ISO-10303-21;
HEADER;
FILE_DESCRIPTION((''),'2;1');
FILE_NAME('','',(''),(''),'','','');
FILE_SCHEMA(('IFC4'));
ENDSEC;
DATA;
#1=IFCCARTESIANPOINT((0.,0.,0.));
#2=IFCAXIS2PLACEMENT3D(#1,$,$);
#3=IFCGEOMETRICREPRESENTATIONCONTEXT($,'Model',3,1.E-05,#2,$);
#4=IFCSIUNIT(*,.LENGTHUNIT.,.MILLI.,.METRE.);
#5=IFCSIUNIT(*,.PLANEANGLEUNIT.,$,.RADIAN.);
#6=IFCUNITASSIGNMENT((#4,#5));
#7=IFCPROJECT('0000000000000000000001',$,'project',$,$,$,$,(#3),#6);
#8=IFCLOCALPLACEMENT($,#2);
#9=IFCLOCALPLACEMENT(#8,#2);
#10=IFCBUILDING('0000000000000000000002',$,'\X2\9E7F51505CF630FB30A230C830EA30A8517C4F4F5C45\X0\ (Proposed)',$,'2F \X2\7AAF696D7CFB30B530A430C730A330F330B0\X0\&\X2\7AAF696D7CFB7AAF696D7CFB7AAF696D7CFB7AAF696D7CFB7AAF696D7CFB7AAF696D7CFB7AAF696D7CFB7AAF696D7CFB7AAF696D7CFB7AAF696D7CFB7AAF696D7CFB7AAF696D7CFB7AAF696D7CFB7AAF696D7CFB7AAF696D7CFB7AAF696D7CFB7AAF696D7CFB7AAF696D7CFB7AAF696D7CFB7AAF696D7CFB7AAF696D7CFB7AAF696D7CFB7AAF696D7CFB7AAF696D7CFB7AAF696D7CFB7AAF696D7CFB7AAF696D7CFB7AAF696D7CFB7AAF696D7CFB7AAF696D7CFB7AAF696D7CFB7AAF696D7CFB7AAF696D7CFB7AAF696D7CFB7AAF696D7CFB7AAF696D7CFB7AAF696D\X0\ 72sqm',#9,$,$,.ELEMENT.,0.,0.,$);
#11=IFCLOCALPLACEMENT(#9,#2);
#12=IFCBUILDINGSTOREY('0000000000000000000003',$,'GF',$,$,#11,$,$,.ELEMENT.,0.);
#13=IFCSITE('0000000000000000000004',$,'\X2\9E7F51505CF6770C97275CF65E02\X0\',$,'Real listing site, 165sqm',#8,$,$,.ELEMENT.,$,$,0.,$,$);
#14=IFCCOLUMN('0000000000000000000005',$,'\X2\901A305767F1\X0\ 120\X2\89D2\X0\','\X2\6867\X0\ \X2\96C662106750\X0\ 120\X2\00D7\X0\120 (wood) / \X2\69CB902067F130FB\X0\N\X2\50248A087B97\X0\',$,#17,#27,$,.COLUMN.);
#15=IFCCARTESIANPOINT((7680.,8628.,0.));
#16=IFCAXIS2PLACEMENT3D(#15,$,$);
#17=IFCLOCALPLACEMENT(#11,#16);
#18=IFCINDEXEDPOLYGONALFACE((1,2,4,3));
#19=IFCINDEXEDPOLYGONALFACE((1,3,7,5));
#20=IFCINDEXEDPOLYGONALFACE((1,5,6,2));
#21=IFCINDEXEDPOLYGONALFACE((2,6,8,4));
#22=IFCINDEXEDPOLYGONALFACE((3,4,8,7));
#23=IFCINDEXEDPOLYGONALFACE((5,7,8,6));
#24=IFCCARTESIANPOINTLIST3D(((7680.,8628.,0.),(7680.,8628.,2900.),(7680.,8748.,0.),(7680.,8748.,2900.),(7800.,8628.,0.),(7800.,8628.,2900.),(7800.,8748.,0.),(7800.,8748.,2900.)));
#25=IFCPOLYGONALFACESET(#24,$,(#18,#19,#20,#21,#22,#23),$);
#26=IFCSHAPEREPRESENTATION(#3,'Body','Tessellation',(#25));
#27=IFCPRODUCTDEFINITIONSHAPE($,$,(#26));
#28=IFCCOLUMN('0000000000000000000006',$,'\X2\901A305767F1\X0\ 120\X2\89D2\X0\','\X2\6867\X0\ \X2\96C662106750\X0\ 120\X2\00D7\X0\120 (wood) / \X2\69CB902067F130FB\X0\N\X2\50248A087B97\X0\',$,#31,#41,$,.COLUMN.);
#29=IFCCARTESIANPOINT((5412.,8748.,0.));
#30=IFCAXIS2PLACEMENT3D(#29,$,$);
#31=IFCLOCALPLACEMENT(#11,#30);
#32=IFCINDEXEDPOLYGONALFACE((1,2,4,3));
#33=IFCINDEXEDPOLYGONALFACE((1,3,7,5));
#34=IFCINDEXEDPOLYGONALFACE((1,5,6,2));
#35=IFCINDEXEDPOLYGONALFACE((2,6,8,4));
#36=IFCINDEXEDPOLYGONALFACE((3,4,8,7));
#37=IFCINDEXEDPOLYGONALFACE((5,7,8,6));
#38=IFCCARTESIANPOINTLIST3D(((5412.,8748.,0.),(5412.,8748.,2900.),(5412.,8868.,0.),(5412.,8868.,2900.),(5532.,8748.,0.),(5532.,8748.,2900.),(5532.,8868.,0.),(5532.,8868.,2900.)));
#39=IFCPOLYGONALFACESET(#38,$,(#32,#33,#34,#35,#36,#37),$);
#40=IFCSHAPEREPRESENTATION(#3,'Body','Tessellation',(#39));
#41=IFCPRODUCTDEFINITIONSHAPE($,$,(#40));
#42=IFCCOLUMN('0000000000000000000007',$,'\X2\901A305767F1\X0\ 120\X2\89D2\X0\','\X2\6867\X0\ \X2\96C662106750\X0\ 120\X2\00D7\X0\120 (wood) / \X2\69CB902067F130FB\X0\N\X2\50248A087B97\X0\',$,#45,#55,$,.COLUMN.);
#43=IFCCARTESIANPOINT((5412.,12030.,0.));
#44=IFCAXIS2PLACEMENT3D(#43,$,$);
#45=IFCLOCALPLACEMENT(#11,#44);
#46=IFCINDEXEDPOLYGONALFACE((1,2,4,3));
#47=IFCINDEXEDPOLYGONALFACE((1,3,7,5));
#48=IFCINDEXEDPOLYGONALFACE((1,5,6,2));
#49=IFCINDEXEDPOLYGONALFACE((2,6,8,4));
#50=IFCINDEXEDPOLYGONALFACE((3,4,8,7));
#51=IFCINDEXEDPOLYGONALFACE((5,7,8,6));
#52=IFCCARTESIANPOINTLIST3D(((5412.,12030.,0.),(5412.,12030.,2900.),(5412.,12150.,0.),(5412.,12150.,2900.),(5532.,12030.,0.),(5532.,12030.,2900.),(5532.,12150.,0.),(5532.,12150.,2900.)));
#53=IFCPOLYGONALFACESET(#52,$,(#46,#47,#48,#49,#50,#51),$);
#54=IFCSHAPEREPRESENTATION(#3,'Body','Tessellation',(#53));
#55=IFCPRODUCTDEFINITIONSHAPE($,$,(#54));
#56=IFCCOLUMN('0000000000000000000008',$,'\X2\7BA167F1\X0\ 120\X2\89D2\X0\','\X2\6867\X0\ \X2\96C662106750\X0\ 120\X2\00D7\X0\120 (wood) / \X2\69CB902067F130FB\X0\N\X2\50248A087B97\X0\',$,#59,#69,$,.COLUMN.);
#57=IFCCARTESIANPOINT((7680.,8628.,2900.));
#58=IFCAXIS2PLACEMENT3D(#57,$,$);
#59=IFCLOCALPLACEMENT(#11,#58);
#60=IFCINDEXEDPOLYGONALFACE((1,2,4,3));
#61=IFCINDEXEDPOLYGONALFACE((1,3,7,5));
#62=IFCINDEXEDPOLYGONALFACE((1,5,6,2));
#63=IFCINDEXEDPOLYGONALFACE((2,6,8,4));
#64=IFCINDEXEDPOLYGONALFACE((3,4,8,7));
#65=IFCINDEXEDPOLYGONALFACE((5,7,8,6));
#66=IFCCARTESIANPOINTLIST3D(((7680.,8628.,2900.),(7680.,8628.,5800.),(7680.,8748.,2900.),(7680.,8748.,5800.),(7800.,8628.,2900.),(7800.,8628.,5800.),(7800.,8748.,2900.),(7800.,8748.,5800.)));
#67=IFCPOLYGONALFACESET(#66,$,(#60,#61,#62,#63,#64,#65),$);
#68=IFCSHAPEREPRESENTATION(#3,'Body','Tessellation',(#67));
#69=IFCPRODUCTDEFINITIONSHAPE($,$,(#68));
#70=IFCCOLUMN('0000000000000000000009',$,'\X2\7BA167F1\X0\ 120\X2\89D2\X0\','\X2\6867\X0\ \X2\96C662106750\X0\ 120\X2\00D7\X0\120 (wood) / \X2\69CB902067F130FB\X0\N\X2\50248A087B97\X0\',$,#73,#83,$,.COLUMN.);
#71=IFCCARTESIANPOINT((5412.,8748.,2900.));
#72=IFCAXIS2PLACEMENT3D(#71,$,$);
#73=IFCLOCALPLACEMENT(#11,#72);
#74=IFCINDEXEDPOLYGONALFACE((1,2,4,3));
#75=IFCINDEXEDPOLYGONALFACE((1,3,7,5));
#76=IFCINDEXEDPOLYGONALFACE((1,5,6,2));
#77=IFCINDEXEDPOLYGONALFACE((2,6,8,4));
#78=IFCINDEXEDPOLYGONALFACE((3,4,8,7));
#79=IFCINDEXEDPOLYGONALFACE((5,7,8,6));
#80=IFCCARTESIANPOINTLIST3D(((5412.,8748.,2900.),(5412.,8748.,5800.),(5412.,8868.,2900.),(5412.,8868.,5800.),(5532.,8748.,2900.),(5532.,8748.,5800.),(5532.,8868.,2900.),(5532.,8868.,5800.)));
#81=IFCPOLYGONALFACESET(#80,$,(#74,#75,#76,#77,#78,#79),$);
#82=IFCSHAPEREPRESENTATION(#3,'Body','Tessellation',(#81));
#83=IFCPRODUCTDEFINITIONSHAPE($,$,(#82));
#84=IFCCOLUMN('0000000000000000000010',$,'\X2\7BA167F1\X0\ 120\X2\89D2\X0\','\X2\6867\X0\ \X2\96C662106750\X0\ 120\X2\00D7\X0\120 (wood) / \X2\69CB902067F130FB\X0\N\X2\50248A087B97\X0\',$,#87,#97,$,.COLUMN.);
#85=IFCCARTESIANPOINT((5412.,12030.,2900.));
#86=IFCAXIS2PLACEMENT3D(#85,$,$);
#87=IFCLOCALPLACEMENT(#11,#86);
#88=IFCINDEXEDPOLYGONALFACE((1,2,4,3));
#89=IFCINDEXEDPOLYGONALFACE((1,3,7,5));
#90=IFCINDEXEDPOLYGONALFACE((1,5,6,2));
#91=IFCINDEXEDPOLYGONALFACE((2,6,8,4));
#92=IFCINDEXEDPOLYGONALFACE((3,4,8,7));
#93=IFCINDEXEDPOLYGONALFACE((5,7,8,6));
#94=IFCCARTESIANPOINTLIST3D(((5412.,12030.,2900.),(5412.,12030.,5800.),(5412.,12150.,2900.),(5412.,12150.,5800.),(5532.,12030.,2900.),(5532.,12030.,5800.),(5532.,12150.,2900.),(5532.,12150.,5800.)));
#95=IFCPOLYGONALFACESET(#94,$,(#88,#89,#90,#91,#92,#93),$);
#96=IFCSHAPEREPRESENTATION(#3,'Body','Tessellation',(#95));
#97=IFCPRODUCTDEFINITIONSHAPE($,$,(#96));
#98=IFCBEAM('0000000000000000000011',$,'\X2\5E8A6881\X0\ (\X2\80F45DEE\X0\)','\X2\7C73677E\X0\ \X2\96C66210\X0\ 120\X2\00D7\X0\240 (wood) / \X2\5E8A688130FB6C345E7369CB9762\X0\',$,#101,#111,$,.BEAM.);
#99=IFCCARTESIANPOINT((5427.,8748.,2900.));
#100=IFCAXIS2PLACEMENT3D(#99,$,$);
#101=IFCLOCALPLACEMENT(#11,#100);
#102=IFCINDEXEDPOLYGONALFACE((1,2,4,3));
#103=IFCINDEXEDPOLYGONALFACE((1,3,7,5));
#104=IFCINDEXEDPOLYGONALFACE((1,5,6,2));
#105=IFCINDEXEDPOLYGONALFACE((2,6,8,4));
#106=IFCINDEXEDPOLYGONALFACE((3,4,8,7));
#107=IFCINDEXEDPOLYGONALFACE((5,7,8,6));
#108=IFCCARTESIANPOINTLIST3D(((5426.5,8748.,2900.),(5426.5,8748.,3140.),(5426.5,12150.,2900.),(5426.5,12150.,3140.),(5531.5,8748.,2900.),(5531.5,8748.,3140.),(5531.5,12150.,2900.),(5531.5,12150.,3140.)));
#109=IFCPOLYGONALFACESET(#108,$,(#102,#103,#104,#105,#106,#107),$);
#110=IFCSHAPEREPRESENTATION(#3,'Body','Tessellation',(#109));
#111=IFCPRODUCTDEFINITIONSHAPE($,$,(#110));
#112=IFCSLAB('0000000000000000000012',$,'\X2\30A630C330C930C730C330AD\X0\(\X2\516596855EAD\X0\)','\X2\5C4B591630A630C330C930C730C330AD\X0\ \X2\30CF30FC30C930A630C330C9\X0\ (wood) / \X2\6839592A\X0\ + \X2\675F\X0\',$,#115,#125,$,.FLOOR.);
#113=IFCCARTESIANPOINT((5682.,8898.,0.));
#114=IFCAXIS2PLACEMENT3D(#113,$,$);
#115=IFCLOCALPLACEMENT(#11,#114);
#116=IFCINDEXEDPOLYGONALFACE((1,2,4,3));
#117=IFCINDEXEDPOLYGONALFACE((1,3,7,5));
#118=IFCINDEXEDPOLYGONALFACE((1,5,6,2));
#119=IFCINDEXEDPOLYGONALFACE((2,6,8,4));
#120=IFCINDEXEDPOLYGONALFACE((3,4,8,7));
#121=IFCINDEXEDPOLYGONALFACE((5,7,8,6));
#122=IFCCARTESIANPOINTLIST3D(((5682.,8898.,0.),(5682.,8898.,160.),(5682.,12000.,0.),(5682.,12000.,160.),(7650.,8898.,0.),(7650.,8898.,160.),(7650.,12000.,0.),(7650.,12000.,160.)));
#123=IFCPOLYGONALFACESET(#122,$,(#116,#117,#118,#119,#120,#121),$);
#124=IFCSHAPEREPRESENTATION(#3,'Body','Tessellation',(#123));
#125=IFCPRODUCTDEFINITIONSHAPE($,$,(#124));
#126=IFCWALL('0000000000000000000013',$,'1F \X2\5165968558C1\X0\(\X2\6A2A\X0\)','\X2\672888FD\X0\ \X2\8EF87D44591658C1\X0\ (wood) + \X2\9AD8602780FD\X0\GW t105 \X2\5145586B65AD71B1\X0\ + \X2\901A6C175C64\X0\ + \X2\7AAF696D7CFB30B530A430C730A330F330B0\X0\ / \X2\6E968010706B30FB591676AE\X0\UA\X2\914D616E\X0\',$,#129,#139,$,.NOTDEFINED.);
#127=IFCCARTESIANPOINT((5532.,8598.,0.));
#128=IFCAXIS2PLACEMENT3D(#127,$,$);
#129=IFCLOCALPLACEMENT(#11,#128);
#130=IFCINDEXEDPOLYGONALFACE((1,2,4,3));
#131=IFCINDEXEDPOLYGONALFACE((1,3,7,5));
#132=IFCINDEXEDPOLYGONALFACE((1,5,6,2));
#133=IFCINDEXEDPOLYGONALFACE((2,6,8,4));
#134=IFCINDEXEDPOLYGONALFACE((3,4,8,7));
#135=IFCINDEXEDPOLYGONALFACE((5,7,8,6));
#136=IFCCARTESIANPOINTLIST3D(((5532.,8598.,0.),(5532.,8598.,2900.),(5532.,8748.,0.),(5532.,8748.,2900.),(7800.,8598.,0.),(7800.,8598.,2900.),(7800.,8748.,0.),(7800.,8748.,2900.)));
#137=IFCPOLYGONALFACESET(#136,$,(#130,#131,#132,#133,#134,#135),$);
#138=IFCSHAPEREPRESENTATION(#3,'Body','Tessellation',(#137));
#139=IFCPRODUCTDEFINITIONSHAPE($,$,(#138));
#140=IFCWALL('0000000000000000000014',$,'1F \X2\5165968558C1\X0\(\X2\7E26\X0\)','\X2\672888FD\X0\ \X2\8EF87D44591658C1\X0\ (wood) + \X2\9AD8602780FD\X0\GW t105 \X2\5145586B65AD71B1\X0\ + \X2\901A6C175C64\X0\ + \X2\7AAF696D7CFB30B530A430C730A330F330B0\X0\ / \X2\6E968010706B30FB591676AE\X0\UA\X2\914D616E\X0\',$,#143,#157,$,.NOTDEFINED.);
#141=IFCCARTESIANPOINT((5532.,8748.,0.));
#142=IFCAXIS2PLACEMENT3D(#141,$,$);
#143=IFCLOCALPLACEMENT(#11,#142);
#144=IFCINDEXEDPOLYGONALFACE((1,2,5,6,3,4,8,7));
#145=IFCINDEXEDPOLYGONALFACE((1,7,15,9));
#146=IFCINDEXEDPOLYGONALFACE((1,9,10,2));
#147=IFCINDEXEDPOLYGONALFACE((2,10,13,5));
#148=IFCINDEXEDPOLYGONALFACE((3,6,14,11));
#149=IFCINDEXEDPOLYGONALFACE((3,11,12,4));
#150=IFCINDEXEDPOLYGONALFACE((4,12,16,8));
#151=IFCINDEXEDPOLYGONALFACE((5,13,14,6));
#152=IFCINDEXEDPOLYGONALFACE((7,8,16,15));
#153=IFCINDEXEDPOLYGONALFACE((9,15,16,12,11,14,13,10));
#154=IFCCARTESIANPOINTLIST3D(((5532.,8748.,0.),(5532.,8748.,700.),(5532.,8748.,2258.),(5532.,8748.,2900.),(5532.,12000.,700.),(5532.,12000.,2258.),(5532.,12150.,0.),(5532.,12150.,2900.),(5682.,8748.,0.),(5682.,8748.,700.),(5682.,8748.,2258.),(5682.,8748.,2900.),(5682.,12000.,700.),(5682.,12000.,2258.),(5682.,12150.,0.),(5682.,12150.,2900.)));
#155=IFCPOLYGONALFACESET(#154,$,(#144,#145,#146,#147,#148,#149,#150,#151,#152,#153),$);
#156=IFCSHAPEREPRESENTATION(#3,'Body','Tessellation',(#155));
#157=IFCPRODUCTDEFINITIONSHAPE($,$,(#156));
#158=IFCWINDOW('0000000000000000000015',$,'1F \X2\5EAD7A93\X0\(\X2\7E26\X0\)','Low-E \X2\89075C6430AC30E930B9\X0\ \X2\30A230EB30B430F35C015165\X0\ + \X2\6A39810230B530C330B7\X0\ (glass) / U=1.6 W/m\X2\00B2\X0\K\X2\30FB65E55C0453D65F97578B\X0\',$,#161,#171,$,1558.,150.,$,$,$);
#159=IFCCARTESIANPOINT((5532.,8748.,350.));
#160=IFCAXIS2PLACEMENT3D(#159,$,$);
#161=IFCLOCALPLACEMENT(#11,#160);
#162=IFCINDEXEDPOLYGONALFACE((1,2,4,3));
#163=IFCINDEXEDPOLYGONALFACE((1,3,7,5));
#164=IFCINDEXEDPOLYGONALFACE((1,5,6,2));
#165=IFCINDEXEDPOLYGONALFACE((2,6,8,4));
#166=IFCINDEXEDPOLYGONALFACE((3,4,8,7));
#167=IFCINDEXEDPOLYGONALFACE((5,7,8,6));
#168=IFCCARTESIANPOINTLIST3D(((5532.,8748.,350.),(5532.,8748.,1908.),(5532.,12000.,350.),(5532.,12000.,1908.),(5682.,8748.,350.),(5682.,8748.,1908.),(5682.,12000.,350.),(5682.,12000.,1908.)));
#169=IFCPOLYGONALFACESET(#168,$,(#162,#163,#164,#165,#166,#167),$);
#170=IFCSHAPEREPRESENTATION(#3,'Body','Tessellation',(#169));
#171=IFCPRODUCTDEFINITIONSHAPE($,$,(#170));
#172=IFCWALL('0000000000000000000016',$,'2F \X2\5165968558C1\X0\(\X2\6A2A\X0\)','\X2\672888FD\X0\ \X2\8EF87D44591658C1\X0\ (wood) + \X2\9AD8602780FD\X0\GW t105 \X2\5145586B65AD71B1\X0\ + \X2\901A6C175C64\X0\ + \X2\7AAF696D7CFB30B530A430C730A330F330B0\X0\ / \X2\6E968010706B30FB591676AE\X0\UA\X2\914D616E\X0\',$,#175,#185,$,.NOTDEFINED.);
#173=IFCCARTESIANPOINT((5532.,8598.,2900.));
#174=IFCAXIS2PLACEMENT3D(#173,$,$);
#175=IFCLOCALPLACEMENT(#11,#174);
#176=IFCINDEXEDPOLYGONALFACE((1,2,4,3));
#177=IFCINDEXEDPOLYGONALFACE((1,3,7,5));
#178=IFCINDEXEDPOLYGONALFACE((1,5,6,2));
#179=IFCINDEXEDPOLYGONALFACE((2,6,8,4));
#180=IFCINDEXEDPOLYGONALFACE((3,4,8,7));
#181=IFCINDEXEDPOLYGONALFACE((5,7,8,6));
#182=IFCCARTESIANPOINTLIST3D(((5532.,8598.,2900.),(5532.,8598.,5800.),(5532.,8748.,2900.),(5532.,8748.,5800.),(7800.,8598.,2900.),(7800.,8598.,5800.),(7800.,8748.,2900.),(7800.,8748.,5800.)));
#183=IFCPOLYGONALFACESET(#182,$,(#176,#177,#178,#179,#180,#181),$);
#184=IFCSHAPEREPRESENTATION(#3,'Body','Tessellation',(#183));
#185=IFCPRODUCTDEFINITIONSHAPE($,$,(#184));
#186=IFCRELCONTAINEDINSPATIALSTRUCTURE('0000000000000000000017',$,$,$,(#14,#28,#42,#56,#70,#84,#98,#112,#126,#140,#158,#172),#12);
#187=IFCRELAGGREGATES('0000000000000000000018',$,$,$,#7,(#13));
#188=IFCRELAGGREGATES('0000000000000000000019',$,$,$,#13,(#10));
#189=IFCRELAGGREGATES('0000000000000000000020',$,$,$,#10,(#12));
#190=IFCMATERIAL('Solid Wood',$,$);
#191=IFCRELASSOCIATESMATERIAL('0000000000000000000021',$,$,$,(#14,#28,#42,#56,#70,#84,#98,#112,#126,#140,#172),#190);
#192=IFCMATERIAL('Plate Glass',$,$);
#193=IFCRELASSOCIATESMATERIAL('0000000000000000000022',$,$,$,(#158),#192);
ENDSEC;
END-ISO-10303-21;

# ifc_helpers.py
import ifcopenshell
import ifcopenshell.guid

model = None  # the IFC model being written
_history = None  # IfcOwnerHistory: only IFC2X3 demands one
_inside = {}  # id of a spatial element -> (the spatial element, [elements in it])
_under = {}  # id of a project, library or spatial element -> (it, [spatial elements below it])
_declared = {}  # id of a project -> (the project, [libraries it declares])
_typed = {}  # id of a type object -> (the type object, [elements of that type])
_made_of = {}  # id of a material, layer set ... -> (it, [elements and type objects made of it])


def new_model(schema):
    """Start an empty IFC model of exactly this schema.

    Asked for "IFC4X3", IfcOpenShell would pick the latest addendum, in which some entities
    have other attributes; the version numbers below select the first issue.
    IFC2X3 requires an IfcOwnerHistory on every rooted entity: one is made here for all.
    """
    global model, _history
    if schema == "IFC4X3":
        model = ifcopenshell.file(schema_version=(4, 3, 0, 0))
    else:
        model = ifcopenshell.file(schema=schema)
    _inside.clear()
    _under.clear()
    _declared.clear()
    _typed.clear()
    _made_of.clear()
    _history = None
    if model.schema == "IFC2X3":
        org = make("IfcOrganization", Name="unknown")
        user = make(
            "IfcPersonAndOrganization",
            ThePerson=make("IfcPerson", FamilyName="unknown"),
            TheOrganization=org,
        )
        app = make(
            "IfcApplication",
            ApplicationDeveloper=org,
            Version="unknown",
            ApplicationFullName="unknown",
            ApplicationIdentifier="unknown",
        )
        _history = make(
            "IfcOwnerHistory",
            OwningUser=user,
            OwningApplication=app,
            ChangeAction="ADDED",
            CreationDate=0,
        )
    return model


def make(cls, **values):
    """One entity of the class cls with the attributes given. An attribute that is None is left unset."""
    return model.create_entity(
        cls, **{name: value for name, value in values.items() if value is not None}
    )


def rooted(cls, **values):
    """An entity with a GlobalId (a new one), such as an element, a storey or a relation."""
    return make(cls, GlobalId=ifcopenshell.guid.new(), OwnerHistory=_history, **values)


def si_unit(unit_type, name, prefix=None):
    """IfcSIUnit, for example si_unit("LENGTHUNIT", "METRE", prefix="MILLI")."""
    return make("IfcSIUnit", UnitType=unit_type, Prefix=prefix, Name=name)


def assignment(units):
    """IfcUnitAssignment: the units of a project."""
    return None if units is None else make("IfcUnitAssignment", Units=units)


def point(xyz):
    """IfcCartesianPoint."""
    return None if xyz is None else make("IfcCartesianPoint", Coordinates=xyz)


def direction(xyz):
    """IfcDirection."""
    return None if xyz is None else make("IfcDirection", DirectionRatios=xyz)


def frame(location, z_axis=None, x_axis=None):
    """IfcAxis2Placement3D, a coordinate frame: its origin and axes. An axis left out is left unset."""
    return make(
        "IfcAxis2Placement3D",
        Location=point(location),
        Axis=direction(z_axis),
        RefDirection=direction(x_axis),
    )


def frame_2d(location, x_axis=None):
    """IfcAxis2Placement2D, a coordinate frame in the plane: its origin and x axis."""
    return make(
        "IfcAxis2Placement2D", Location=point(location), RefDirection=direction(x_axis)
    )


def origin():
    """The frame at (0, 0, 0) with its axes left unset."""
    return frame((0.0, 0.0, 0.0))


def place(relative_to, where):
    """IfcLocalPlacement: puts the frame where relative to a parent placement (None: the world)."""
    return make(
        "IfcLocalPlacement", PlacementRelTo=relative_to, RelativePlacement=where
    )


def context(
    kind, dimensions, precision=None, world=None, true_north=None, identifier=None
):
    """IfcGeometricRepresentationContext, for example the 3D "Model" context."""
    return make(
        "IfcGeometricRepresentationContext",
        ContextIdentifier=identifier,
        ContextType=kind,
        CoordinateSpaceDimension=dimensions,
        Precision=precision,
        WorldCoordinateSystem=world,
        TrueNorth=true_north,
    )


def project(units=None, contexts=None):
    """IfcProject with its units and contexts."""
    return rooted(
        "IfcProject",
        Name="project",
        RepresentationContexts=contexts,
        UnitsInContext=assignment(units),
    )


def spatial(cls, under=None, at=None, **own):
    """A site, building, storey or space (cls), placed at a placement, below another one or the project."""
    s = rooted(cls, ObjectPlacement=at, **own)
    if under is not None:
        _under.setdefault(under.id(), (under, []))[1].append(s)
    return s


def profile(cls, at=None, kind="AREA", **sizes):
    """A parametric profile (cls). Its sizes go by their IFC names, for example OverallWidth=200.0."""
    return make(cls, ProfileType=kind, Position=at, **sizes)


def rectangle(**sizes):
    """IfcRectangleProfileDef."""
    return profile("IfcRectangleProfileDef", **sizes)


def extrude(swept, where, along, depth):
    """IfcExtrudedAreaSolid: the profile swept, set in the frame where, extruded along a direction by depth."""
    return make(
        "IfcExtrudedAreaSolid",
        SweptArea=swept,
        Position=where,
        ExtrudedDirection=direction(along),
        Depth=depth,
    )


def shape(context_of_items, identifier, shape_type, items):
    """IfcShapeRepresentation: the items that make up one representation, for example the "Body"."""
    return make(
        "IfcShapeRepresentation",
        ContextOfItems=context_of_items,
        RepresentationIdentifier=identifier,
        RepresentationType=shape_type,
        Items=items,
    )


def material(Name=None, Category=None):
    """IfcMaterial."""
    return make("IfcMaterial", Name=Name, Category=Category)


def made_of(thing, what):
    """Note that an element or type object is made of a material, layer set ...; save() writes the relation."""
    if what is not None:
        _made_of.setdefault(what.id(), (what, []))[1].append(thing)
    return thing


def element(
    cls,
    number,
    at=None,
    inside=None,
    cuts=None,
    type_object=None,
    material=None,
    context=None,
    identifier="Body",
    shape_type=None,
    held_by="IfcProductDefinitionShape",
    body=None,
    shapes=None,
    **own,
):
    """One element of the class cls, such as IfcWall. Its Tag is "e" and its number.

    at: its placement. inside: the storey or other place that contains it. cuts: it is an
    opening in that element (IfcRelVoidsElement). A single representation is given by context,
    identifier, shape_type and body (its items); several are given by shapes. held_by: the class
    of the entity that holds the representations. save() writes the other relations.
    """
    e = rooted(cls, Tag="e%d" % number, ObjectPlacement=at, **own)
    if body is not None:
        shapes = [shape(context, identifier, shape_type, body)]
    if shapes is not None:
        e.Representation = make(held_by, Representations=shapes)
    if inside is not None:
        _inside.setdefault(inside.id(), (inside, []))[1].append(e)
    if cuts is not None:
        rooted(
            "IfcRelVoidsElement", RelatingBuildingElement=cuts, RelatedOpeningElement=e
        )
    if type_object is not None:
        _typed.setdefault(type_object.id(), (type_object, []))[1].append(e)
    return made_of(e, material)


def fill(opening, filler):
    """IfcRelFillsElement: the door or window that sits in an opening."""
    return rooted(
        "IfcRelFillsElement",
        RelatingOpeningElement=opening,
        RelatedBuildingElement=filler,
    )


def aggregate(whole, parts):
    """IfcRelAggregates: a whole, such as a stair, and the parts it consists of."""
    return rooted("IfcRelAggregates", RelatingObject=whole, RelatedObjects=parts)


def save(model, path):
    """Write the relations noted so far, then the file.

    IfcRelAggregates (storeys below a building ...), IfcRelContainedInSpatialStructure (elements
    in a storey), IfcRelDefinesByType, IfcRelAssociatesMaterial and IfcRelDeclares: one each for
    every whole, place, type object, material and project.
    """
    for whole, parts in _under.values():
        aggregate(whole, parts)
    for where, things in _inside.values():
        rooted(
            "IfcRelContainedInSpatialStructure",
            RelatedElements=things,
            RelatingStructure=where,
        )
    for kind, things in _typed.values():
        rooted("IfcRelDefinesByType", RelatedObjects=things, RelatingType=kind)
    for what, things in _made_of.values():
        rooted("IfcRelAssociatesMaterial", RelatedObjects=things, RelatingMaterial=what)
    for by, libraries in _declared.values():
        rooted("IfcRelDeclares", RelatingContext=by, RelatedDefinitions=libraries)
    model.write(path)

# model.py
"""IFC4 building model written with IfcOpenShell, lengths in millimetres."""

from ifc_helpers import new_model, si_unit, frame, frame_2d, origin, place, context, project, spatial, rectangle, extrude, material, element, fill, save


model = new_model("IFC4")

# Units and contexts
model_context = context("Model", 3, precision=1e-05, world=origin())
ifc_project = project(units=[si_unit("LENGTHUNIT", "METRE", prefix="MILLI"), si_unit("PLANEANGLEUNIT", "RADIAN")], contexts=[model_context])

# Site, building, storey
site_placement = place(None, origin())
site = spatial("IfcSite", under=ifc_project, at=site_placement, Name="鹿児島県霧島市", ObjectType="Real listing site, 165sqm", CompositionType="ELEMENT", RefElevation=0.0)
building_placement = place(site_placement, origin())
building = spatial("IfcBuilding", under=site, at=building_placement, Name="鹿児島・アトリエ兼住居 (Proposed)", ObjectType="2F 窯業系サイディング&窯業系窯業系窯業系窯業系窯業系窯業系窯業系窯業系窯業系窯業系窯業系窯業系窯業系窯業系窯業系窯業系窯業系窯業系窯業系窯業系窯業系窯業系窯業系窯業系窯業系窯業系窯業系窯業系窯業系窯業系窯業系窯業系窯業系窯業系窯業系窯業系窯業 72sqm", CompositionType="ELEMENT", ElevationOfRefHeight=0.0, ElevationOfTerrain=0.0)
storey_placement = place(building_placement, origin())
storey = spatial("IfcBuildingStorey", under=building, at=storey_placement, Name="GF", CompositionType="ELEMENT", Elevation=0.0)

# Columns
ifc_material_1 = material(Name="Solid Wood")
column_1_placement = place(storey_placement, frame((7680.0, 8628.0, 0.0)))
element("IfcColumn", 1, at=column_1_placement, inside=storey, material=ifc_material_1, Name="通し柱 120角", Description="桧 集成材 120×120 (wood) / 構造柱・N値計算", PredefinedType="COLUMN", context=model_context, shape_type="SweptSolid", body=[
    extrude(rectangle(XDim=120.0, YDim=120.0, at=frame_2d((60.0, 60.0))), frame((7680.0, 8628.0, 0.0)), (0.0, 0.0, 1.0), 2900.0),
])
column_2_placement = place(storey_placement, frame((5412.0, 8748.0, 0.0)))
element("IfcColumn", 2, at=column_2_placement, inside=storey, material=ifc_material_1, Name="通し柱 120角", Description="桧 集成材 120×120 (wood) / 構造柱・N値計算", PredefinedType="COLUMN", context=model_context, shape_type="SweptSolid", body=[
    extrude(rectangle(XDim=120.0, YDim=120.0, at=frame_2d((60.0, 60.0))), frame((5412.0, 8748.0, 0.0)), (0.0, 0.0, 1.0), 2900.0),
])
column_3_placement = place(storey_placement, frame((5412.0, 12030.0, 0.0)))
element("IfcColumn", 3, at=column_3_placement, inside=storey, material=ifc_material_1, Name="通し柱 120角", Description="桧 集成材 120×120 (wood) / 構造柱・N値計算", PredefinedType="COLUMN", context=model_context, shape_type="SweptSolid", body=[
    extrude(rectangle(XDim=120.0, YDim=120.0, at=frame_2d((60.0, 60.0))), frame((5412.0, 12030.0, 0.0)), (0.0, 0.0, 1.0), 2900.0),
])
column_4_placement = place(storey_placement, frame((7680.0, 8628.0, 2900.0)))
element("IfcColumn", 4, at=column_4_placement, inside=storey, material=ifc_material_1, Name="管柱 120角", Description="桧 集成材 120×120 (wood) / 構造柱・N値計算", PredefinedType="COLUMN", context=model_context, shape_type="SweptSolid", body=[
    extrude(rectangle(XDim=120.0, YDim=120.0, at=frame_2d((60.0, 60.0))), frame((7680.0, 8628.0, 2900.0)), (0.0, 0.0, 1.0), 2900.0),
])
column_5_placement = place(storey_placement, frame((5412.0, 8748.0, 2900.0)))
element("IfcColumn", 5, at=column_5_placement, inside=storey, material=ifc_material_1, Name="管柱 120角", Description="桧 集成材 120×120 (wood) / 構造柱・N値計算", PredefinedType="COLUMN", context=model_context, shape_type="SweptSolid", body=[
    extrude(rectangle(XDim=120.0, YDim=120.0, at=frame_2d((60.0, 60.0))), frame((5412.0, 8748.0, 2900.0)), (0.0, 0.0, 1.0), 2900.0),
])
column_6_placement = place(storey_placement, frame((5412.0, 12030.0, 2900.0)))
element("IfcColumn", 6, at=column_6_placement, inside=storey, material=ifc_material_1, Name="管柱 120角", Description="桧 集成材 120×120 (wood) / 構造柱・N値計算", PredefinedType="COLUMN", context=model_context, shape_type="SweptSolid", body=[
    extrude(rectangle(XDim=120.0, YDim=120.0, at=frame_2d((60.0, 60.0))), frame((5412.0, 12030.0, 2900.0)), (0.0, 0.0, 1.0), 2900.0),
])

# Beam
beam_1_placement = place(storey_placement, frame((5427.0, 8748.0, 2900.0)))
element("IfcBeam", 7, at=beam_1_placement, inside=storey, material=ifc_material_1, Name="床梁 (胴差)", Description="米松 集成 120×240 (wood) / 床梁・水平構面", PredefinedType="BEAM", context=model_context, shape_type="SweptSolid", body=[
    extrude(rectangle(XDim=105.0, YDim=3402.0, at=frame_2d((52.0, 1701.0))), frame((5427.0, 8748.0, 2900.0)), (0.0, 0.0, 1.0), 240.0),
])

# Slab
slab_placement = place(storey_placement, frame((5682.0, 8898.0, 0.0)))
element("IfcSlab", 8, at=slab_placement, inside=storey, material=ifc_material_1, Name="ウッドデッキ(入隅庭)", Description="屋外ウッドデッキ ハードウッド (wood) / 根太 + 束", PredefinedType="FLOOR", context=model_context, shape_type="SweptSolid", body=[
    extrude(rectangle(XDim=1968.0, YDim=3102.0, at=frame_2d((984.0, 1551.0))), frame((5682.0, 8898.0, 0.0)), (0.0, 0.0, 1.0), 160.0),
])

# Wall
wall_1_placement = place(storey_placement, frame((5532.0, 8598.0, 0.0)))
element("IfcWall", 9, at=wall_1_placement, inside=storey, material=ifc_material_1, Name="1F 入隅壁(横)", Description="木製 軸組外壁 (wood) + 高性能GW t105 充填断熱 + 通気層 + 窯業系サイディング / 準耐火・外皮UA配慮", PredefinedType="NOTDEFINED", context=model_context, shape_type="SweptSolid", body=[
    extrude(rectangle(XDim=2268.0, YDim=150.0, at=frame_2d((1134.0, 75.0))), frame((5532.0, 8598.0, 0.0)), (0.0, 0.0, 1.0), 2900.0),
])

# Wall, opening, window
wall_2_placement = place(storey_placement, frame((5532.0, 8748.0, 0.0)))
wall_2 = element("IfcWall", 10, at=wall_2_placement, inside=storey, material=ifc_material_1, Name="1F 入隅壁(縦)", Description="木製 軸組外壁 (wood) + 高性能GW t105 充填断熱 + 通気層 + 窯業系サイディング / 準耐火・外皮UA配慮", PredefinedType="NOTDEFINED", context=model_context, shape_type="SweptSolid", body=[
    extrude(rectangle(XDim=150.0, YDim=3402.0, at=frame_2d((75.0, 1701.0))), frame((5532.0, 8748.0, 0.0)), (0.0, 0.0, 1.0), 2900.0),
])
opening_1_placement = place(storey_placement, frame((5532.0, 8748.0, 350.0)))
opening_1 = element("IfcOpeningElement", 11, at=opening_1_placement, cuts=wall_2, PredefinedType="NOTDEFINED", context=model_context, shape_type="SweptSolid", body=[
    extrude(rectangle(XDim=150.0, YDim=3252.0, at=frame_2d((75.0, 1626.0))), frame((5532.0, 8748.0, 350.0)), (0.0, 0.0, 1.0), 1558.0),
])
ifc_material_2 = material(Name="Plate Glass")
window_1_placement = place(storey_placement, frame((5532.0, 8748.0, 350.0)))
window_1 = element("IfcWindow", 12, at=window_1_placement, inside=storey, material=ifc_material_2, Name="1F 庭窓(縦)", Description="Low-E 複層ガラス アルゴン封入 + 樹脂サッシ (glass) / U=1.6 W/m²K・日射取得型", OverallHeight=1558.0, OverallWidth=150.0, context=model_context, shape_type="SweptSolid", body=[
    extrude(rectangle(XDim=150.0, YDim=3252.0, at=frame_2d((75.0, 1626.0))), frame((5532.0, 8748.0, 350.0)), (0.0, 0.0, 1.0), 1558.0),
])
fill(opening_1, window_1)

# Wall
wall_3_placement = place(storey_placement, frame((5532.0, 8598.0, 2900.0)))
element("IfcWall", 13, at=wall_3_placement, inside=storey, material=ifc_material_1, Name="2F 入隅壁(横)", Description="木製 軸組外壁 (wood) + 高性能GW t105 充填断熱 + 通気層 + 窯業系サイディング / 準耐火・外皮UA配慮", PredefinedType="NOTDEFINED", context=model_context, shape_type="SweptSolid", body=[
    extrude(rectangle(XDim=2268.0, YDim=150.0, at=frame_2d((1134.0, 75.0))), frame((5532.0, 8598.0, 2900.0)), (0.0, 0.0, 1.0), 2900.0),
])

save(model, "model.ifc")
